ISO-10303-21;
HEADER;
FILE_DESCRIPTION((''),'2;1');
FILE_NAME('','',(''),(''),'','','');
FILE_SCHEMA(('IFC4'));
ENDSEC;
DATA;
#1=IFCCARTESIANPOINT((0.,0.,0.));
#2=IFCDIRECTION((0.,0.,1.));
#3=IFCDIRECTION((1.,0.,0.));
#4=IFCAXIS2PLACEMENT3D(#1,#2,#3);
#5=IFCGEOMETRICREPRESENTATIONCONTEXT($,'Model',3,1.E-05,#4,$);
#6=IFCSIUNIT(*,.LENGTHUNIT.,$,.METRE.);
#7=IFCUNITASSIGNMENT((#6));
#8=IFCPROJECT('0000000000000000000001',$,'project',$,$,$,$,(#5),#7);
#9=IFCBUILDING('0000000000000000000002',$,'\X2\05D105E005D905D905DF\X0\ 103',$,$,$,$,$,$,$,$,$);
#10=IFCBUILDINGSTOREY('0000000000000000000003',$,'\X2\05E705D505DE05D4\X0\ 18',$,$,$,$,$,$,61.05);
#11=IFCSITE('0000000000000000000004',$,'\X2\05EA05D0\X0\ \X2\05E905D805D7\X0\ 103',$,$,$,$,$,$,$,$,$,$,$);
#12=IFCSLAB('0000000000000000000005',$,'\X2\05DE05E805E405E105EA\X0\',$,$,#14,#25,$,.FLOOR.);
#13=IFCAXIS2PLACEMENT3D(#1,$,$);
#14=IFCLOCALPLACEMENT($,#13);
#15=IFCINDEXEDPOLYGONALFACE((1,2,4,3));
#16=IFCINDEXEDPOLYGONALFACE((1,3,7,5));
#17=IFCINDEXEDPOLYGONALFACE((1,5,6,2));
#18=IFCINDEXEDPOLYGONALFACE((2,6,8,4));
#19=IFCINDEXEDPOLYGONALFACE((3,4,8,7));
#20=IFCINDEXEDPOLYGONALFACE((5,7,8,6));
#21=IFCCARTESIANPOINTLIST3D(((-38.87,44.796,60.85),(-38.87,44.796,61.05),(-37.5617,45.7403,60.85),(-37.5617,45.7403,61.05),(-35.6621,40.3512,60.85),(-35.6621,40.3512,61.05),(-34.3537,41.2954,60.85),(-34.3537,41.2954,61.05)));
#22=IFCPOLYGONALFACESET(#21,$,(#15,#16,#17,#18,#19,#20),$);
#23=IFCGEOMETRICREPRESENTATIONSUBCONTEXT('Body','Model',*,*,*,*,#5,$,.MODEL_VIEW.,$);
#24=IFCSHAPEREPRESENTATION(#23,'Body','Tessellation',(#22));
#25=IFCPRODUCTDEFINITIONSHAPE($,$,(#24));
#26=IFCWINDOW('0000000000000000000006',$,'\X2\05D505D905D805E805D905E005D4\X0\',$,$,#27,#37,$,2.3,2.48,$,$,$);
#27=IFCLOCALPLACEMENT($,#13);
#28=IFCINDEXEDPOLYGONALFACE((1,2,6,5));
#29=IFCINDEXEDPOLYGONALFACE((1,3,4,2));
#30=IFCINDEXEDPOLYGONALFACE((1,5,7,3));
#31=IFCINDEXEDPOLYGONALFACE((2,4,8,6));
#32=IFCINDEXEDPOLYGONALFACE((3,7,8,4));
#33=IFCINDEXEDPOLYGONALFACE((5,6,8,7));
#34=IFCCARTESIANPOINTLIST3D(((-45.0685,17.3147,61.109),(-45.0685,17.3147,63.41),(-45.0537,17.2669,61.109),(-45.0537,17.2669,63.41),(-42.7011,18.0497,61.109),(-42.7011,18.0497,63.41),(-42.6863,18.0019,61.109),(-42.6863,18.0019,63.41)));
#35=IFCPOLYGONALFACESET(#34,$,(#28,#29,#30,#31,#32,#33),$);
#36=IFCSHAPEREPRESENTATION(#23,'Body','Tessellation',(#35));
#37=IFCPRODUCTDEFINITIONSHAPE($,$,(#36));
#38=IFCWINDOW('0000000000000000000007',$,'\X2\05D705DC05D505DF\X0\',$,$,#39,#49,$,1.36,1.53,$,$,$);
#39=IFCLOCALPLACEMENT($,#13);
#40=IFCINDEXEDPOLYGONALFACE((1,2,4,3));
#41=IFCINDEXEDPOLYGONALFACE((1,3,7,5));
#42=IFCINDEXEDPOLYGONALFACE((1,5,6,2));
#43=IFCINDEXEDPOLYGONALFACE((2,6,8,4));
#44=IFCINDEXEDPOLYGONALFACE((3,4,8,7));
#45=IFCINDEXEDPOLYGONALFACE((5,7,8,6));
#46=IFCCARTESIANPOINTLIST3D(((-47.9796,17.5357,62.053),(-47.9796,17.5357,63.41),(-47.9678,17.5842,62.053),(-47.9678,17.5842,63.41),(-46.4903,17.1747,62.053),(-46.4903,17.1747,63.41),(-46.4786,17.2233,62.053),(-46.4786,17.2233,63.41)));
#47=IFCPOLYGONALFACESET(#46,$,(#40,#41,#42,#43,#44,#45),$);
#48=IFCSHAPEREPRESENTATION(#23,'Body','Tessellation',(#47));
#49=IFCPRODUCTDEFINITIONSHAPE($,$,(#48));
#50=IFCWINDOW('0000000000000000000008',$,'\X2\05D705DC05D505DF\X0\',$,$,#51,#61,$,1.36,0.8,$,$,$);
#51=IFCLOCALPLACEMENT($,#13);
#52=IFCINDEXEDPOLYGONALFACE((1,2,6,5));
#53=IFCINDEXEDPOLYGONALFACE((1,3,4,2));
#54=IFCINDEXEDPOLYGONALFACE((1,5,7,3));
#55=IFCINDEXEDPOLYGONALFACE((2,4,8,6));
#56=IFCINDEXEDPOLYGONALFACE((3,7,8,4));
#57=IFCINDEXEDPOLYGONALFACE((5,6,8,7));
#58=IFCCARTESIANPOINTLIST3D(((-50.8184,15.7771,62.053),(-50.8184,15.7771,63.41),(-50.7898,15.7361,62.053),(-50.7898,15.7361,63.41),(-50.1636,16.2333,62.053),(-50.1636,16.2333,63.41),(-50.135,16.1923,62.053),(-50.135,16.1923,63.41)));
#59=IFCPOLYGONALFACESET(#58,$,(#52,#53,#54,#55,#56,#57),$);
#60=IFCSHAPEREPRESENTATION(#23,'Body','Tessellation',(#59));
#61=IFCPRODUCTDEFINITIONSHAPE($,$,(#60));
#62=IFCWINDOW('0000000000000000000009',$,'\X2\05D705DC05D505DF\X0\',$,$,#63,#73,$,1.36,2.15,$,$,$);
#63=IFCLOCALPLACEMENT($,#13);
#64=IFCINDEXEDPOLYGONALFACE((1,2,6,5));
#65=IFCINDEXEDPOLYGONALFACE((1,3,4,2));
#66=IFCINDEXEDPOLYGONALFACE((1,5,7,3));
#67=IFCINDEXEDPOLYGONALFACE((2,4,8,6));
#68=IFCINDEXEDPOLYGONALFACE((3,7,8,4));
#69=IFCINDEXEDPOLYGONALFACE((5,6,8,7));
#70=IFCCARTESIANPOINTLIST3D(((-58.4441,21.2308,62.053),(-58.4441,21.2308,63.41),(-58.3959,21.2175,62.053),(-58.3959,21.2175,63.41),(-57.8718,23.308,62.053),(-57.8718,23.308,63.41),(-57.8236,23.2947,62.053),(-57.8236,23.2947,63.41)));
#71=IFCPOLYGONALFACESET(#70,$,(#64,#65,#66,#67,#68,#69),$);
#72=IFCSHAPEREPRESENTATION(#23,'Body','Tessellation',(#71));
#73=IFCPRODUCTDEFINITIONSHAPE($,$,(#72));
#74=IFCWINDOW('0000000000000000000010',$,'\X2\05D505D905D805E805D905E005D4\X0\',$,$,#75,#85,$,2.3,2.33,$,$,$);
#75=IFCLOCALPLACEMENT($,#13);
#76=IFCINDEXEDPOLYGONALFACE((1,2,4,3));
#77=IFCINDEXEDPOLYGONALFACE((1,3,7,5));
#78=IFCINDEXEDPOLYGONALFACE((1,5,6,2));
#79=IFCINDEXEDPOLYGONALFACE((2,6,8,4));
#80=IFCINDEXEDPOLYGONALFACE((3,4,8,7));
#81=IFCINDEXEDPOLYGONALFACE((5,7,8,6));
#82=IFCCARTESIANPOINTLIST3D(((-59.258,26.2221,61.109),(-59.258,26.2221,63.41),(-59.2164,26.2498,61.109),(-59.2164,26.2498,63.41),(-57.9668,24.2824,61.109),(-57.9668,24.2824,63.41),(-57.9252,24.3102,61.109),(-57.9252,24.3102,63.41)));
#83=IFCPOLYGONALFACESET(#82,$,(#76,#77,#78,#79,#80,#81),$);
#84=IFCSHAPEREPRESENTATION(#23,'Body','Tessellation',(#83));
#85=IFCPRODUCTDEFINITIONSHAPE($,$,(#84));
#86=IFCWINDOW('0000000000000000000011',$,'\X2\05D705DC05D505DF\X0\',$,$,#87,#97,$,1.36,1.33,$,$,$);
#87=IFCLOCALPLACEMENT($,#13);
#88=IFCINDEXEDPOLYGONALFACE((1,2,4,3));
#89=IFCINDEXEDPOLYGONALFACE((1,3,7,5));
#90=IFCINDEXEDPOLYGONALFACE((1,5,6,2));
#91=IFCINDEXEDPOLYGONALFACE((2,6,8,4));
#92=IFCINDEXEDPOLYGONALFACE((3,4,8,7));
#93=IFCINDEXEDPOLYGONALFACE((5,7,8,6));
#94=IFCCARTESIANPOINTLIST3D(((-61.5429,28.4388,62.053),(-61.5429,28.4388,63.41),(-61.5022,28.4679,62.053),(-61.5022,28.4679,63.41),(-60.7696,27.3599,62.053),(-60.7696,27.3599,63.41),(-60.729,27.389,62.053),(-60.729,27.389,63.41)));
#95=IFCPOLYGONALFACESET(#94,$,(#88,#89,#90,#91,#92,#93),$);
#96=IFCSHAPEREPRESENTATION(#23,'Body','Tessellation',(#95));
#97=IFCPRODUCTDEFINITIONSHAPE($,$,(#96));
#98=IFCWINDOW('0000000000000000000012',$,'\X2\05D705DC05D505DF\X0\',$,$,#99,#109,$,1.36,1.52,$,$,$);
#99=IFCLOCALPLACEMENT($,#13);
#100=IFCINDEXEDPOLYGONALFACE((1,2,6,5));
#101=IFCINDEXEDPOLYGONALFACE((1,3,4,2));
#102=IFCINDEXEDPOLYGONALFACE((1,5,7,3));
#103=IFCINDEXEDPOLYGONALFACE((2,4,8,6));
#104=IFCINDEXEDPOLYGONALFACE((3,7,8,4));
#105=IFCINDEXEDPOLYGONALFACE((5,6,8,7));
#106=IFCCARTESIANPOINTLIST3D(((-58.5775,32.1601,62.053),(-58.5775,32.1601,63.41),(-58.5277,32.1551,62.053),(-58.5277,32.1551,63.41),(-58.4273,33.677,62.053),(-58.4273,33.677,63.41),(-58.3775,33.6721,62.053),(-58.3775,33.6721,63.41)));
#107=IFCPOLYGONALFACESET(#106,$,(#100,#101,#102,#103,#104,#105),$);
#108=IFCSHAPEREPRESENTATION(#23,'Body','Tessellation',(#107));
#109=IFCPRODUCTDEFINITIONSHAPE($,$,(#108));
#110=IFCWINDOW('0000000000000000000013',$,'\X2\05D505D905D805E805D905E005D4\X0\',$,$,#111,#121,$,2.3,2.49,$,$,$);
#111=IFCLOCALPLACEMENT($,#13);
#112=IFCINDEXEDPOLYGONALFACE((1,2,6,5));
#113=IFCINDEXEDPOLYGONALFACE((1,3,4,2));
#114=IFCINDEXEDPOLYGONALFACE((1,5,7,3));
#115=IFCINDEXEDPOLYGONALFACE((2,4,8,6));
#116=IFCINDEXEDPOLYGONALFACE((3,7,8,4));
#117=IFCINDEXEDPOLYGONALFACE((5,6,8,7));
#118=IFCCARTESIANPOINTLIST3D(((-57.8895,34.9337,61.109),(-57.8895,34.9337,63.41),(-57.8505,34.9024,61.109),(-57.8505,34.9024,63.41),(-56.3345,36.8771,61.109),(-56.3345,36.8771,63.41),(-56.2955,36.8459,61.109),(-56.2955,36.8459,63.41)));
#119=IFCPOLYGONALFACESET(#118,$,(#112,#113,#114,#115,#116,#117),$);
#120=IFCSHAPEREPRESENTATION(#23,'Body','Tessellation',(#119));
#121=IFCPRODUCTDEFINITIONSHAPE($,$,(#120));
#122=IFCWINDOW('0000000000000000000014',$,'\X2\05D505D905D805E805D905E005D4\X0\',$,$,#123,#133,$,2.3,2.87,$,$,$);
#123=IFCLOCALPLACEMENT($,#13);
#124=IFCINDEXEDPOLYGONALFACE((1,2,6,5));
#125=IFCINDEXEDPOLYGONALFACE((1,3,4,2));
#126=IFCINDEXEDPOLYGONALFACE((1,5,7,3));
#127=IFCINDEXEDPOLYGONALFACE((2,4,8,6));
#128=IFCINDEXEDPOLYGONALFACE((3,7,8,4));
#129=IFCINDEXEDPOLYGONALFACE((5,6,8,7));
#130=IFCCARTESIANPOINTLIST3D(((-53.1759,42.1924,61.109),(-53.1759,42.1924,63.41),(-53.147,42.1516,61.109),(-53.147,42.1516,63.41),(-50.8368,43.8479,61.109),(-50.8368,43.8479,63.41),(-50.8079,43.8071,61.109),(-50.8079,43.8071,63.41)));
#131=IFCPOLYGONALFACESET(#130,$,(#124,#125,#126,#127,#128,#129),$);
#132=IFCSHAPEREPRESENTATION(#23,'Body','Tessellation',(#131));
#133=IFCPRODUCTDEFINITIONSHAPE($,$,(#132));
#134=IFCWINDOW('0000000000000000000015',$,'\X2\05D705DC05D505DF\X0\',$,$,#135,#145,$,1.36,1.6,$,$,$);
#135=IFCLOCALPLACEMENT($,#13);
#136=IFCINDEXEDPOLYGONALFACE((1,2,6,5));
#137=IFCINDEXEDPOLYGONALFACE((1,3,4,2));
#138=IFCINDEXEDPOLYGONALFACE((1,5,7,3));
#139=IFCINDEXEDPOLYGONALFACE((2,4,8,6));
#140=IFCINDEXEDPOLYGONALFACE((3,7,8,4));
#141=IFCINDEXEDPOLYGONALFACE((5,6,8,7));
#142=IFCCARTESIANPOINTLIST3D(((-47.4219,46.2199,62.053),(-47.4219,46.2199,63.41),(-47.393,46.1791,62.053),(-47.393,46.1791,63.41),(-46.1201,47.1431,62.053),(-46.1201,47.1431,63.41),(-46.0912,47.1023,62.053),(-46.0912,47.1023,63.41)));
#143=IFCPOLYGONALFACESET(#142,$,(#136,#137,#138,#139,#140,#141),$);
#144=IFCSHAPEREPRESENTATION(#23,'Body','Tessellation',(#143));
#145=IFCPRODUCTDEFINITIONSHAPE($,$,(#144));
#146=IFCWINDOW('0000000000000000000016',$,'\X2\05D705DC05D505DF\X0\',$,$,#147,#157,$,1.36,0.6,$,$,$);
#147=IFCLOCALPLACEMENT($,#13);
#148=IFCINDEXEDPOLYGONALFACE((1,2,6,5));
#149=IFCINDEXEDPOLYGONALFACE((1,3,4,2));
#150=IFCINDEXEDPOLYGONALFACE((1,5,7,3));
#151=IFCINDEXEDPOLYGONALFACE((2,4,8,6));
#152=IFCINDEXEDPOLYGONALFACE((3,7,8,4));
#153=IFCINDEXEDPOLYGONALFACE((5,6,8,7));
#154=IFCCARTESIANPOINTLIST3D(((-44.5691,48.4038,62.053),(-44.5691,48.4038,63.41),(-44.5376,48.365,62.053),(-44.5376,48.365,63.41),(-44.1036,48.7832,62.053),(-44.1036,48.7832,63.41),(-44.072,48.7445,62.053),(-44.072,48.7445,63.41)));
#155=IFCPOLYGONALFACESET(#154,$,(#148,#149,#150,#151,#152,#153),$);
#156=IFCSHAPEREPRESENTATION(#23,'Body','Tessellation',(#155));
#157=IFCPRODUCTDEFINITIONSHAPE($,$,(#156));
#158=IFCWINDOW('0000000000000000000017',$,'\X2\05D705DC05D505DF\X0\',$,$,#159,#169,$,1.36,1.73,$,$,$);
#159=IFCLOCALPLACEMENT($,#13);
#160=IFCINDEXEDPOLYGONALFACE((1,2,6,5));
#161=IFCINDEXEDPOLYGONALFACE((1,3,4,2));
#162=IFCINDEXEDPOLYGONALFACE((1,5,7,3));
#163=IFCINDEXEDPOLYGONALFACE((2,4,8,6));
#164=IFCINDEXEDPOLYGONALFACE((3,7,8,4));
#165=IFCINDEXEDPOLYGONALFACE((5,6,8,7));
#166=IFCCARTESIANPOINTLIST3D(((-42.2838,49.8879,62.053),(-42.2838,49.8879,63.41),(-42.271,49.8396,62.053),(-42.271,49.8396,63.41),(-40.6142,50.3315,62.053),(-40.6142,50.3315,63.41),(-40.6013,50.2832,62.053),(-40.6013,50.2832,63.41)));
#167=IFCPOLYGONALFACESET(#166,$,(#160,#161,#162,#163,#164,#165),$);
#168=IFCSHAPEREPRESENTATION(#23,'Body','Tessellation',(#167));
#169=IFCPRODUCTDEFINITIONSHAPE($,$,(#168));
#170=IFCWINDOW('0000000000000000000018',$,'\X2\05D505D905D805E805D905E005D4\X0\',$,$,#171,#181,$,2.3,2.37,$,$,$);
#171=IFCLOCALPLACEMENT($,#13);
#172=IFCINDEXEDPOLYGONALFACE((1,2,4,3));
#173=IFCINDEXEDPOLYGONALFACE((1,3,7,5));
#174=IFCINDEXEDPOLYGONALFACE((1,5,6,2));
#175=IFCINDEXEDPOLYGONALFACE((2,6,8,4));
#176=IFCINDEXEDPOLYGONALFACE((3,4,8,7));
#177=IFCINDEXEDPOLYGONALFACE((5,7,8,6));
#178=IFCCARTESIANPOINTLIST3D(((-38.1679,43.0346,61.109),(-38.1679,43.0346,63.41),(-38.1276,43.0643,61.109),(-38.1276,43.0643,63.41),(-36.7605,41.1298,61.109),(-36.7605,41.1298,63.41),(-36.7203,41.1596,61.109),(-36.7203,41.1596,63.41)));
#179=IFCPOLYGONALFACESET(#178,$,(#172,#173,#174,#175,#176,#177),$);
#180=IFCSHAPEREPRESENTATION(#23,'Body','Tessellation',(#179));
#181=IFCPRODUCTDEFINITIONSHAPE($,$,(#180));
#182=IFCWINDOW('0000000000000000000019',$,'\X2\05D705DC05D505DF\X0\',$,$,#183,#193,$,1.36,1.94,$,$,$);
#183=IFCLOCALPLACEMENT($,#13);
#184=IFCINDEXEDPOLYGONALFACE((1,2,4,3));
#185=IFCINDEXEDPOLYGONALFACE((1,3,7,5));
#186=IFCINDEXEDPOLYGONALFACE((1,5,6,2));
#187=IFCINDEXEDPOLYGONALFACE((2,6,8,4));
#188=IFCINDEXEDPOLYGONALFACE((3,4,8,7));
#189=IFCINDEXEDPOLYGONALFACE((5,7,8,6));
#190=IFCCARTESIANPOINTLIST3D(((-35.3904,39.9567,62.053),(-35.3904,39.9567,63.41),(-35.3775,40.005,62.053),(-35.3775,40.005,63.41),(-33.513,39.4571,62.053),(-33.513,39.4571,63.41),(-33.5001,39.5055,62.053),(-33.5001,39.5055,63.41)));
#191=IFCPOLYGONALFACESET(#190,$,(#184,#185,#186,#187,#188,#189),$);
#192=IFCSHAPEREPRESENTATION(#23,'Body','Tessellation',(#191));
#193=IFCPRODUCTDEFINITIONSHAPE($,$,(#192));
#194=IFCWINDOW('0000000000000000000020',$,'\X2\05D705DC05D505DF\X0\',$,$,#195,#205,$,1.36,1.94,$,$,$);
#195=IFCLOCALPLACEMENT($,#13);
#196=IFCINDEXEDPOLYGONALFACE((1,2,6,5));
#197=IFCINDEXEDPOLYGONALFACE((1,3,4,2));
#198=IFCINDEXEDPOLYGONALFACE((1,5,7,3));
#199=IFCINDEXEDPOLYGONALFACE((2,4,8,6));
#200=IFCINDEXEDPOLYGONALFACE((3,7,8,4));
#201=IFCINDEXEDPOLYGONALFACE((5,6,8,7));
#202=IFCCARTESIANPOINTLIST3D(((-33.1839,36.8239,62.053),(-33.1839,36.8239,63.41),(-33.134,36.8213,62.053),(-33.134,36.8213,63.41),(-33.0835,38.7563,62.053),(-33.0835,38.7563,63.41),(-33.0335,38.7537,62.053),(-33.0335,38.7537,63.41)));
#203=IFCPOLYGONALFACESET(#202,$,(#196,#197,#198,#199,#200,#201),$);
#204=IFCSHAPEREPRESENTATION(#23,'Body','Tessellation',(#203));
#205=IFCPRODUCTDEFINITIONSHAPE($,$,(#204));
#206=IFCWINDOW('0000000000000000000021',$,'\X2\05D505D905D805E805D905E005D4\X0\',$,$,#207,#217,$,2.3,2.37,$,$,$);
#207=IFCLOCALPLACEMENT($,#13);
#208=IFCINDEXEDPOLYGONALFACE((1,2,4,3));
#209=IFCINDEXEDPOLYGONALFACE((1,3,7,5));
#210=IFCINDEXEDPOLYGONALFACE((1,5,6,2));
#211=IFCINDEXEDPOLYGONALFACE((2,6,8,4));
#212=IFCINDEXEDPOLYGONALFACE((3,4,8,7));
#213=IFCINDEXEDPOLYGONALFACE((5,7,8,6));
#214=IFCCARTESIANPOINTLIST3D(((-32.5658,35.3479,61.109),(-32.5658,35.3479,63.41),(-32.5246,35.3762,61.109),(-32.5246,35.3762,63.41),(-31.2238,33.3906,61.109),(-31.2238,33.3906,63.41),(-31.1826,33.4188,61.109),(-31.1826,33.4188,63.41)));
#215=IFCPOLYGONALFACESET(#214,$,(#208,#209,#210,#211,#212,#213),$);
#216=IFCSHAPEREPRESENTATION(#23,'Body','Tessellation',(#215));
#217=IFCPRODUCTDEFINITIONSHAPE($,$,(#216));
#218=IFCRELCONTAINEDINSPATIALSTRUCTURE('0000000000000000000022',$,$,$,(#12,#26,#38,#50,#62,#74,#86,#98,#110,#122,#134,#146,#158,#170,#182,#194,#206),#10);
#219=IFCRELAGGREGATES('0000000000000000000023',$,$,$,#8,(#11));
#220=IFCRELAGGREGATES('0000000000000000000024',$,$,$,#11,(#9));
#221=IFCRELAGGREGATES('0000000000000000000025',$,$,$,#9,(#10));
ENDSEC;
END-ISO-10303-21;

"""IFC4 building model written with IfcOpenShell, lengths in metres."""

from ifc_helpers import new_model, si_unit, frame, origin_with_axes, context, subcontext, project, spatial, polyline, outline, extrude, element, save


model = new_model("IFC4")

# Units and contexts
model_context = context("Model", 3, precision=1e-05, world=origin_with_axes())
body_context = subcontext(model_context, "Body", "Model", "MODEL_VIEW")
ifc_project = project(units=[si_unit("LENGTHUNIT", "METRE")], contexts=[model_context])

# Site, building, storey
site = spatial("IfcSite", under=ifc_project, Name="תא שטח 103")
building = spatial("IfcBuilding", under=site, Name="בניין 103")
storey = spatial("IfcBuildingStorey", under=building, Name="קומה 18", Elevation=61.05)

# Slab
element("IfcSlab", 1, inside=storey, Name="מרפסת", PredefinedType="FLOOR", context=body_context, shape_type="SweptSolid", body=[
    extrude(outline(polyline([(-34.3537, 41.2954), (-37.5617, 45.7403), (-38.87, 44.796), (-35.6621, 40.3512), (-34.3537, 41.2954)])), frame((0.0, 0.0, 60.85)), (0.0, 0.0, 1.0), 0.2),
])

# Windows
element("IfcWindow", 2, inside=storey, Name="ויטרינה", OverallHeight=2.3, OverallWidth=2.48, context=body_context, shape_type="SweptSolid", body=[
    extrude(outline(polyline([(-42.7011, 18.0497), (-45.0685, 17.3147), (-45.0537, 17.2669), (-42.6863, 18.0019), (-42.7011, 18.0497)])), frame((0.0, 0.0, 61.109)), (0.0, 0.0, 1.0), 2.301),
])
element("IfcWindow", 3, inside=storey, Name="חלון", OverallHeight=1.36, OverallWidth=1.53, context=body_context, shape_type="SweptSolid", body=[
    extrude(outline(polyline([(-46.4786, 17.2233), (-47.9678, 17.5842), (-47.9796, 17.5357), (-46.4903, 17.1747), (-46.4786, 17.2233)])), frame((0.0, 0.0, 62.053)), (0.0, 0.0, 1.0), 1.357),
])
element("IfcWindow", 4, inside=storey, Name="חלון", OverallHeight=1.36, OverallWidth=0.8, context=body_context, shape_type="SweptSolid", body=[
    extrude(outline(polyline([(-50.1636, 16.2333), (-50.8184, 15.7771), (-50.7898, 15.7361), (-50.135, 16.1923), (-50.1636, 16.2333)])), frame((0.0, 0.0, 62.053)), (0.0, 0.0, 1.0), 1.357),
])
element("IfcWindow", 5, inside=storey, Name="חלון", OverallHeight=1.36, OverallWidth=2.15, context=body_context, shape_type="SweptSolid", body=[
    extrude(outline(polyline([(-58.3959, 21.2175), (-57.8236, 23.2947), (-57.8718, 23.308), (-58.4441, 21.2308), (-58.3959, 21.2175)])), frame((0.0, 0.0, 62.053)), (0.0, 0.0, 1.0), 1.357),
])
element("IfcWindow", 6, inside=storey, Name="ויטרינה", OverallHeight=2.3, OverallWidth=2.33, context=body_context, shape_type="SweptSolid", body=[
    extrude(outline(polyline([(-57.9252, 24.3102), (-59.2164, 26.2498), (-59.258, 26.2221), (-57.9668, 24.2824), (-57.9252, 24.3102)])), frame((0.0, 0.0, 61.109)), (0.0, 0.0, 1.0), 2.301),
])
element("IfcWindow", 7, inside=storey, Name="חלון", OverallHeight=1.36, OverallWidth=1.33, context=body_context, shape_type="SweptSolid", body=[
    extrude(outline(polyline([(-60.729, 27.389), (-61.5022, 28.4679), (-61.5429, 28.4388), (-60.7696, 27.3599), (-60.729, 27.389)])), frame((0.0, 0.0, 62.053)), (0.0, 0.0, 1.0), 1.357),
])
element("IfcWindow", 8, inside=storey, Name="חלון", OverallHeight=1.36, OverallWidth=1.52, context=body_context, shape_type="SweptSolid", body=[
    extrude(outline(polyline([(-58.5277, 32.1551), (-58.3775, 33.6721), (-58.4273, 33.677), (-58.5775, 32.1601), (-58.5277, 32.1551)])), frame((0.0, 0.0, 62.053)), (0.0, 0.0, 1.0), 1.357),
])
element("IfcWindow", 9, inside=storey, Name="ויטרינה", OverallHeight=2.3, OverallWidth=2.49, context=body_context, shape_type="SweptSolid", body=[
    extrude(outline(polyline([(-57.8505, 34.9024), (-56.2955, 36.8459), (-56.3345, 36.8771), (-57.8895, 34.9337), (-57.8505, 34.9024)])), frame((0.0, 0.0, 61.109)), (0.0, 0.0, 1.0), 2.301),
])
element("IfcWindow", 10, inside=storey, Name="ויטרינה", OverallHeight=2.3, OverallWidth=2.87, context=body_context, shape_type="SweptSolid", body=[
    extrude(outline(polyline([(-53.147, 42.1516), (-50.8079, 43.8071), (-50.8368, 43.8479), (-53.1759, 42.1924), (-53.147, 42.1516)])), frame((0.0, 0.0, 61.109)), (0.0, 0.0, 1.0), 2.301),
])
element("IfcWindow", 11, inside=storey, Name="חלון", OverallHeight=1.36, OverallWidth=1.6, context=body_context, shape_type="SweptSolid", body=[
    extrude(outline(polyline([(-47.393, 46.1791), (-46.0912, 47.1023), (-46.1201, 47.1431), (-47.4219, 46.2199), (-47.393, 46.1791)])), frame((0.0, 0.0, 62.053)), (0.0, 0.0, 1.0), 1.357),
])
element("IfcWindow", 12, inside=storey, Name="חלון", OverallHeight=1.36, OverallWidth=0.6, context=body_context, shape_type="SweptSolid", body=[
    extrude(outline(polyline([(-44.5376, 48.365), (-44.072, 48.7445), (-44.1036, 48.7832), (-44.5691, 48.4038), (-44.5376, 48.365)])), frame((0.0, 0.0, 62.053)), (0.0, 0.0, 1.0), 1.357),
])
element("IfcWindow", 13, inside=storey, Name="חלון", OverallHeight=1.36, OverallWidth=1.73, context=body_context, shape_type="SweptSolid", body=[
    extrude(outline(polyline([(-42.271, 49.8396), (-40.6013, 50.2832), (-40.6142, 50.3315), (-42.2838, 49.8879), (-42.271, 49.8396)])), frame((0.0, 0.0, 62.053)), (0.0, 0.0, 1.0), 1.357),
])
element("IfcWindow", 14, inside=storey, Name="ויטרינה", OverallHeight=2.3, OverallWidth=2.37, context=body_context, shape_type="SweptSolid", body=[
    extrude(outline(polyline([(-38.1679, 43.0346), (-36.7605, 41.1298), (-36.7203, 41.1596), (-38.1276, 43.0643), (-38.1679, 43.0346)])), frame((0.0, 0.0, 61.109)), (0.0, 0.0, 1.0), 2.301),
])
element("IfcWindow", 15, inside=storey, Name="חלון", OverallHeight=1.36, OverallWidth=1.94, context=body_context, shape_type="SweptSolid", body=[
    extrude(outline(polyline([(-35.3904, 39.9567), (-33.513, 39.4571), (-33.5001, 39.5055), (-35.3775, 40.005), (-35.3904, 39.9567)])), frame((0.0, 0.0, 62.053)), (0.0, 0.0, 1.0), 1.357),
])
element("IfcWindow", 16, inside=storey, Name="חלון", OverallHeight=1.36, OverallWidth=1.94, context=body_context, shape_type="SweptSolid", body=[
    extrude(outline(polyline([(-33.0835, 38.7563), (-33.1839, 36.8239), (-33.134, 36.8213), (-33.0335, 38.7537), (-33.0835, 38.7563)])), frame((0.0, 0.0, 62.053)), (0.0, 0.0, 1.0), 1.357),
])
element("IfcWindow", 17, inside=storey, Name="ויטרינה", OverallHeight=2.3, OverallWidth=2.37, context=body_context, shape_type="SweptSolid", body=[
    extrude(outline(polyline([(-32.5658, 35.3479), (-31.2238, 33.3906), (-31.1826, 33.4188), (-32.5246, 35.3762), (-32.5658, 35.3479)])), frame((0.0, 0.0, 61.109)), (0.0, 0.0, 1.0), 2.301),
])

save(model, "model.ifc")
